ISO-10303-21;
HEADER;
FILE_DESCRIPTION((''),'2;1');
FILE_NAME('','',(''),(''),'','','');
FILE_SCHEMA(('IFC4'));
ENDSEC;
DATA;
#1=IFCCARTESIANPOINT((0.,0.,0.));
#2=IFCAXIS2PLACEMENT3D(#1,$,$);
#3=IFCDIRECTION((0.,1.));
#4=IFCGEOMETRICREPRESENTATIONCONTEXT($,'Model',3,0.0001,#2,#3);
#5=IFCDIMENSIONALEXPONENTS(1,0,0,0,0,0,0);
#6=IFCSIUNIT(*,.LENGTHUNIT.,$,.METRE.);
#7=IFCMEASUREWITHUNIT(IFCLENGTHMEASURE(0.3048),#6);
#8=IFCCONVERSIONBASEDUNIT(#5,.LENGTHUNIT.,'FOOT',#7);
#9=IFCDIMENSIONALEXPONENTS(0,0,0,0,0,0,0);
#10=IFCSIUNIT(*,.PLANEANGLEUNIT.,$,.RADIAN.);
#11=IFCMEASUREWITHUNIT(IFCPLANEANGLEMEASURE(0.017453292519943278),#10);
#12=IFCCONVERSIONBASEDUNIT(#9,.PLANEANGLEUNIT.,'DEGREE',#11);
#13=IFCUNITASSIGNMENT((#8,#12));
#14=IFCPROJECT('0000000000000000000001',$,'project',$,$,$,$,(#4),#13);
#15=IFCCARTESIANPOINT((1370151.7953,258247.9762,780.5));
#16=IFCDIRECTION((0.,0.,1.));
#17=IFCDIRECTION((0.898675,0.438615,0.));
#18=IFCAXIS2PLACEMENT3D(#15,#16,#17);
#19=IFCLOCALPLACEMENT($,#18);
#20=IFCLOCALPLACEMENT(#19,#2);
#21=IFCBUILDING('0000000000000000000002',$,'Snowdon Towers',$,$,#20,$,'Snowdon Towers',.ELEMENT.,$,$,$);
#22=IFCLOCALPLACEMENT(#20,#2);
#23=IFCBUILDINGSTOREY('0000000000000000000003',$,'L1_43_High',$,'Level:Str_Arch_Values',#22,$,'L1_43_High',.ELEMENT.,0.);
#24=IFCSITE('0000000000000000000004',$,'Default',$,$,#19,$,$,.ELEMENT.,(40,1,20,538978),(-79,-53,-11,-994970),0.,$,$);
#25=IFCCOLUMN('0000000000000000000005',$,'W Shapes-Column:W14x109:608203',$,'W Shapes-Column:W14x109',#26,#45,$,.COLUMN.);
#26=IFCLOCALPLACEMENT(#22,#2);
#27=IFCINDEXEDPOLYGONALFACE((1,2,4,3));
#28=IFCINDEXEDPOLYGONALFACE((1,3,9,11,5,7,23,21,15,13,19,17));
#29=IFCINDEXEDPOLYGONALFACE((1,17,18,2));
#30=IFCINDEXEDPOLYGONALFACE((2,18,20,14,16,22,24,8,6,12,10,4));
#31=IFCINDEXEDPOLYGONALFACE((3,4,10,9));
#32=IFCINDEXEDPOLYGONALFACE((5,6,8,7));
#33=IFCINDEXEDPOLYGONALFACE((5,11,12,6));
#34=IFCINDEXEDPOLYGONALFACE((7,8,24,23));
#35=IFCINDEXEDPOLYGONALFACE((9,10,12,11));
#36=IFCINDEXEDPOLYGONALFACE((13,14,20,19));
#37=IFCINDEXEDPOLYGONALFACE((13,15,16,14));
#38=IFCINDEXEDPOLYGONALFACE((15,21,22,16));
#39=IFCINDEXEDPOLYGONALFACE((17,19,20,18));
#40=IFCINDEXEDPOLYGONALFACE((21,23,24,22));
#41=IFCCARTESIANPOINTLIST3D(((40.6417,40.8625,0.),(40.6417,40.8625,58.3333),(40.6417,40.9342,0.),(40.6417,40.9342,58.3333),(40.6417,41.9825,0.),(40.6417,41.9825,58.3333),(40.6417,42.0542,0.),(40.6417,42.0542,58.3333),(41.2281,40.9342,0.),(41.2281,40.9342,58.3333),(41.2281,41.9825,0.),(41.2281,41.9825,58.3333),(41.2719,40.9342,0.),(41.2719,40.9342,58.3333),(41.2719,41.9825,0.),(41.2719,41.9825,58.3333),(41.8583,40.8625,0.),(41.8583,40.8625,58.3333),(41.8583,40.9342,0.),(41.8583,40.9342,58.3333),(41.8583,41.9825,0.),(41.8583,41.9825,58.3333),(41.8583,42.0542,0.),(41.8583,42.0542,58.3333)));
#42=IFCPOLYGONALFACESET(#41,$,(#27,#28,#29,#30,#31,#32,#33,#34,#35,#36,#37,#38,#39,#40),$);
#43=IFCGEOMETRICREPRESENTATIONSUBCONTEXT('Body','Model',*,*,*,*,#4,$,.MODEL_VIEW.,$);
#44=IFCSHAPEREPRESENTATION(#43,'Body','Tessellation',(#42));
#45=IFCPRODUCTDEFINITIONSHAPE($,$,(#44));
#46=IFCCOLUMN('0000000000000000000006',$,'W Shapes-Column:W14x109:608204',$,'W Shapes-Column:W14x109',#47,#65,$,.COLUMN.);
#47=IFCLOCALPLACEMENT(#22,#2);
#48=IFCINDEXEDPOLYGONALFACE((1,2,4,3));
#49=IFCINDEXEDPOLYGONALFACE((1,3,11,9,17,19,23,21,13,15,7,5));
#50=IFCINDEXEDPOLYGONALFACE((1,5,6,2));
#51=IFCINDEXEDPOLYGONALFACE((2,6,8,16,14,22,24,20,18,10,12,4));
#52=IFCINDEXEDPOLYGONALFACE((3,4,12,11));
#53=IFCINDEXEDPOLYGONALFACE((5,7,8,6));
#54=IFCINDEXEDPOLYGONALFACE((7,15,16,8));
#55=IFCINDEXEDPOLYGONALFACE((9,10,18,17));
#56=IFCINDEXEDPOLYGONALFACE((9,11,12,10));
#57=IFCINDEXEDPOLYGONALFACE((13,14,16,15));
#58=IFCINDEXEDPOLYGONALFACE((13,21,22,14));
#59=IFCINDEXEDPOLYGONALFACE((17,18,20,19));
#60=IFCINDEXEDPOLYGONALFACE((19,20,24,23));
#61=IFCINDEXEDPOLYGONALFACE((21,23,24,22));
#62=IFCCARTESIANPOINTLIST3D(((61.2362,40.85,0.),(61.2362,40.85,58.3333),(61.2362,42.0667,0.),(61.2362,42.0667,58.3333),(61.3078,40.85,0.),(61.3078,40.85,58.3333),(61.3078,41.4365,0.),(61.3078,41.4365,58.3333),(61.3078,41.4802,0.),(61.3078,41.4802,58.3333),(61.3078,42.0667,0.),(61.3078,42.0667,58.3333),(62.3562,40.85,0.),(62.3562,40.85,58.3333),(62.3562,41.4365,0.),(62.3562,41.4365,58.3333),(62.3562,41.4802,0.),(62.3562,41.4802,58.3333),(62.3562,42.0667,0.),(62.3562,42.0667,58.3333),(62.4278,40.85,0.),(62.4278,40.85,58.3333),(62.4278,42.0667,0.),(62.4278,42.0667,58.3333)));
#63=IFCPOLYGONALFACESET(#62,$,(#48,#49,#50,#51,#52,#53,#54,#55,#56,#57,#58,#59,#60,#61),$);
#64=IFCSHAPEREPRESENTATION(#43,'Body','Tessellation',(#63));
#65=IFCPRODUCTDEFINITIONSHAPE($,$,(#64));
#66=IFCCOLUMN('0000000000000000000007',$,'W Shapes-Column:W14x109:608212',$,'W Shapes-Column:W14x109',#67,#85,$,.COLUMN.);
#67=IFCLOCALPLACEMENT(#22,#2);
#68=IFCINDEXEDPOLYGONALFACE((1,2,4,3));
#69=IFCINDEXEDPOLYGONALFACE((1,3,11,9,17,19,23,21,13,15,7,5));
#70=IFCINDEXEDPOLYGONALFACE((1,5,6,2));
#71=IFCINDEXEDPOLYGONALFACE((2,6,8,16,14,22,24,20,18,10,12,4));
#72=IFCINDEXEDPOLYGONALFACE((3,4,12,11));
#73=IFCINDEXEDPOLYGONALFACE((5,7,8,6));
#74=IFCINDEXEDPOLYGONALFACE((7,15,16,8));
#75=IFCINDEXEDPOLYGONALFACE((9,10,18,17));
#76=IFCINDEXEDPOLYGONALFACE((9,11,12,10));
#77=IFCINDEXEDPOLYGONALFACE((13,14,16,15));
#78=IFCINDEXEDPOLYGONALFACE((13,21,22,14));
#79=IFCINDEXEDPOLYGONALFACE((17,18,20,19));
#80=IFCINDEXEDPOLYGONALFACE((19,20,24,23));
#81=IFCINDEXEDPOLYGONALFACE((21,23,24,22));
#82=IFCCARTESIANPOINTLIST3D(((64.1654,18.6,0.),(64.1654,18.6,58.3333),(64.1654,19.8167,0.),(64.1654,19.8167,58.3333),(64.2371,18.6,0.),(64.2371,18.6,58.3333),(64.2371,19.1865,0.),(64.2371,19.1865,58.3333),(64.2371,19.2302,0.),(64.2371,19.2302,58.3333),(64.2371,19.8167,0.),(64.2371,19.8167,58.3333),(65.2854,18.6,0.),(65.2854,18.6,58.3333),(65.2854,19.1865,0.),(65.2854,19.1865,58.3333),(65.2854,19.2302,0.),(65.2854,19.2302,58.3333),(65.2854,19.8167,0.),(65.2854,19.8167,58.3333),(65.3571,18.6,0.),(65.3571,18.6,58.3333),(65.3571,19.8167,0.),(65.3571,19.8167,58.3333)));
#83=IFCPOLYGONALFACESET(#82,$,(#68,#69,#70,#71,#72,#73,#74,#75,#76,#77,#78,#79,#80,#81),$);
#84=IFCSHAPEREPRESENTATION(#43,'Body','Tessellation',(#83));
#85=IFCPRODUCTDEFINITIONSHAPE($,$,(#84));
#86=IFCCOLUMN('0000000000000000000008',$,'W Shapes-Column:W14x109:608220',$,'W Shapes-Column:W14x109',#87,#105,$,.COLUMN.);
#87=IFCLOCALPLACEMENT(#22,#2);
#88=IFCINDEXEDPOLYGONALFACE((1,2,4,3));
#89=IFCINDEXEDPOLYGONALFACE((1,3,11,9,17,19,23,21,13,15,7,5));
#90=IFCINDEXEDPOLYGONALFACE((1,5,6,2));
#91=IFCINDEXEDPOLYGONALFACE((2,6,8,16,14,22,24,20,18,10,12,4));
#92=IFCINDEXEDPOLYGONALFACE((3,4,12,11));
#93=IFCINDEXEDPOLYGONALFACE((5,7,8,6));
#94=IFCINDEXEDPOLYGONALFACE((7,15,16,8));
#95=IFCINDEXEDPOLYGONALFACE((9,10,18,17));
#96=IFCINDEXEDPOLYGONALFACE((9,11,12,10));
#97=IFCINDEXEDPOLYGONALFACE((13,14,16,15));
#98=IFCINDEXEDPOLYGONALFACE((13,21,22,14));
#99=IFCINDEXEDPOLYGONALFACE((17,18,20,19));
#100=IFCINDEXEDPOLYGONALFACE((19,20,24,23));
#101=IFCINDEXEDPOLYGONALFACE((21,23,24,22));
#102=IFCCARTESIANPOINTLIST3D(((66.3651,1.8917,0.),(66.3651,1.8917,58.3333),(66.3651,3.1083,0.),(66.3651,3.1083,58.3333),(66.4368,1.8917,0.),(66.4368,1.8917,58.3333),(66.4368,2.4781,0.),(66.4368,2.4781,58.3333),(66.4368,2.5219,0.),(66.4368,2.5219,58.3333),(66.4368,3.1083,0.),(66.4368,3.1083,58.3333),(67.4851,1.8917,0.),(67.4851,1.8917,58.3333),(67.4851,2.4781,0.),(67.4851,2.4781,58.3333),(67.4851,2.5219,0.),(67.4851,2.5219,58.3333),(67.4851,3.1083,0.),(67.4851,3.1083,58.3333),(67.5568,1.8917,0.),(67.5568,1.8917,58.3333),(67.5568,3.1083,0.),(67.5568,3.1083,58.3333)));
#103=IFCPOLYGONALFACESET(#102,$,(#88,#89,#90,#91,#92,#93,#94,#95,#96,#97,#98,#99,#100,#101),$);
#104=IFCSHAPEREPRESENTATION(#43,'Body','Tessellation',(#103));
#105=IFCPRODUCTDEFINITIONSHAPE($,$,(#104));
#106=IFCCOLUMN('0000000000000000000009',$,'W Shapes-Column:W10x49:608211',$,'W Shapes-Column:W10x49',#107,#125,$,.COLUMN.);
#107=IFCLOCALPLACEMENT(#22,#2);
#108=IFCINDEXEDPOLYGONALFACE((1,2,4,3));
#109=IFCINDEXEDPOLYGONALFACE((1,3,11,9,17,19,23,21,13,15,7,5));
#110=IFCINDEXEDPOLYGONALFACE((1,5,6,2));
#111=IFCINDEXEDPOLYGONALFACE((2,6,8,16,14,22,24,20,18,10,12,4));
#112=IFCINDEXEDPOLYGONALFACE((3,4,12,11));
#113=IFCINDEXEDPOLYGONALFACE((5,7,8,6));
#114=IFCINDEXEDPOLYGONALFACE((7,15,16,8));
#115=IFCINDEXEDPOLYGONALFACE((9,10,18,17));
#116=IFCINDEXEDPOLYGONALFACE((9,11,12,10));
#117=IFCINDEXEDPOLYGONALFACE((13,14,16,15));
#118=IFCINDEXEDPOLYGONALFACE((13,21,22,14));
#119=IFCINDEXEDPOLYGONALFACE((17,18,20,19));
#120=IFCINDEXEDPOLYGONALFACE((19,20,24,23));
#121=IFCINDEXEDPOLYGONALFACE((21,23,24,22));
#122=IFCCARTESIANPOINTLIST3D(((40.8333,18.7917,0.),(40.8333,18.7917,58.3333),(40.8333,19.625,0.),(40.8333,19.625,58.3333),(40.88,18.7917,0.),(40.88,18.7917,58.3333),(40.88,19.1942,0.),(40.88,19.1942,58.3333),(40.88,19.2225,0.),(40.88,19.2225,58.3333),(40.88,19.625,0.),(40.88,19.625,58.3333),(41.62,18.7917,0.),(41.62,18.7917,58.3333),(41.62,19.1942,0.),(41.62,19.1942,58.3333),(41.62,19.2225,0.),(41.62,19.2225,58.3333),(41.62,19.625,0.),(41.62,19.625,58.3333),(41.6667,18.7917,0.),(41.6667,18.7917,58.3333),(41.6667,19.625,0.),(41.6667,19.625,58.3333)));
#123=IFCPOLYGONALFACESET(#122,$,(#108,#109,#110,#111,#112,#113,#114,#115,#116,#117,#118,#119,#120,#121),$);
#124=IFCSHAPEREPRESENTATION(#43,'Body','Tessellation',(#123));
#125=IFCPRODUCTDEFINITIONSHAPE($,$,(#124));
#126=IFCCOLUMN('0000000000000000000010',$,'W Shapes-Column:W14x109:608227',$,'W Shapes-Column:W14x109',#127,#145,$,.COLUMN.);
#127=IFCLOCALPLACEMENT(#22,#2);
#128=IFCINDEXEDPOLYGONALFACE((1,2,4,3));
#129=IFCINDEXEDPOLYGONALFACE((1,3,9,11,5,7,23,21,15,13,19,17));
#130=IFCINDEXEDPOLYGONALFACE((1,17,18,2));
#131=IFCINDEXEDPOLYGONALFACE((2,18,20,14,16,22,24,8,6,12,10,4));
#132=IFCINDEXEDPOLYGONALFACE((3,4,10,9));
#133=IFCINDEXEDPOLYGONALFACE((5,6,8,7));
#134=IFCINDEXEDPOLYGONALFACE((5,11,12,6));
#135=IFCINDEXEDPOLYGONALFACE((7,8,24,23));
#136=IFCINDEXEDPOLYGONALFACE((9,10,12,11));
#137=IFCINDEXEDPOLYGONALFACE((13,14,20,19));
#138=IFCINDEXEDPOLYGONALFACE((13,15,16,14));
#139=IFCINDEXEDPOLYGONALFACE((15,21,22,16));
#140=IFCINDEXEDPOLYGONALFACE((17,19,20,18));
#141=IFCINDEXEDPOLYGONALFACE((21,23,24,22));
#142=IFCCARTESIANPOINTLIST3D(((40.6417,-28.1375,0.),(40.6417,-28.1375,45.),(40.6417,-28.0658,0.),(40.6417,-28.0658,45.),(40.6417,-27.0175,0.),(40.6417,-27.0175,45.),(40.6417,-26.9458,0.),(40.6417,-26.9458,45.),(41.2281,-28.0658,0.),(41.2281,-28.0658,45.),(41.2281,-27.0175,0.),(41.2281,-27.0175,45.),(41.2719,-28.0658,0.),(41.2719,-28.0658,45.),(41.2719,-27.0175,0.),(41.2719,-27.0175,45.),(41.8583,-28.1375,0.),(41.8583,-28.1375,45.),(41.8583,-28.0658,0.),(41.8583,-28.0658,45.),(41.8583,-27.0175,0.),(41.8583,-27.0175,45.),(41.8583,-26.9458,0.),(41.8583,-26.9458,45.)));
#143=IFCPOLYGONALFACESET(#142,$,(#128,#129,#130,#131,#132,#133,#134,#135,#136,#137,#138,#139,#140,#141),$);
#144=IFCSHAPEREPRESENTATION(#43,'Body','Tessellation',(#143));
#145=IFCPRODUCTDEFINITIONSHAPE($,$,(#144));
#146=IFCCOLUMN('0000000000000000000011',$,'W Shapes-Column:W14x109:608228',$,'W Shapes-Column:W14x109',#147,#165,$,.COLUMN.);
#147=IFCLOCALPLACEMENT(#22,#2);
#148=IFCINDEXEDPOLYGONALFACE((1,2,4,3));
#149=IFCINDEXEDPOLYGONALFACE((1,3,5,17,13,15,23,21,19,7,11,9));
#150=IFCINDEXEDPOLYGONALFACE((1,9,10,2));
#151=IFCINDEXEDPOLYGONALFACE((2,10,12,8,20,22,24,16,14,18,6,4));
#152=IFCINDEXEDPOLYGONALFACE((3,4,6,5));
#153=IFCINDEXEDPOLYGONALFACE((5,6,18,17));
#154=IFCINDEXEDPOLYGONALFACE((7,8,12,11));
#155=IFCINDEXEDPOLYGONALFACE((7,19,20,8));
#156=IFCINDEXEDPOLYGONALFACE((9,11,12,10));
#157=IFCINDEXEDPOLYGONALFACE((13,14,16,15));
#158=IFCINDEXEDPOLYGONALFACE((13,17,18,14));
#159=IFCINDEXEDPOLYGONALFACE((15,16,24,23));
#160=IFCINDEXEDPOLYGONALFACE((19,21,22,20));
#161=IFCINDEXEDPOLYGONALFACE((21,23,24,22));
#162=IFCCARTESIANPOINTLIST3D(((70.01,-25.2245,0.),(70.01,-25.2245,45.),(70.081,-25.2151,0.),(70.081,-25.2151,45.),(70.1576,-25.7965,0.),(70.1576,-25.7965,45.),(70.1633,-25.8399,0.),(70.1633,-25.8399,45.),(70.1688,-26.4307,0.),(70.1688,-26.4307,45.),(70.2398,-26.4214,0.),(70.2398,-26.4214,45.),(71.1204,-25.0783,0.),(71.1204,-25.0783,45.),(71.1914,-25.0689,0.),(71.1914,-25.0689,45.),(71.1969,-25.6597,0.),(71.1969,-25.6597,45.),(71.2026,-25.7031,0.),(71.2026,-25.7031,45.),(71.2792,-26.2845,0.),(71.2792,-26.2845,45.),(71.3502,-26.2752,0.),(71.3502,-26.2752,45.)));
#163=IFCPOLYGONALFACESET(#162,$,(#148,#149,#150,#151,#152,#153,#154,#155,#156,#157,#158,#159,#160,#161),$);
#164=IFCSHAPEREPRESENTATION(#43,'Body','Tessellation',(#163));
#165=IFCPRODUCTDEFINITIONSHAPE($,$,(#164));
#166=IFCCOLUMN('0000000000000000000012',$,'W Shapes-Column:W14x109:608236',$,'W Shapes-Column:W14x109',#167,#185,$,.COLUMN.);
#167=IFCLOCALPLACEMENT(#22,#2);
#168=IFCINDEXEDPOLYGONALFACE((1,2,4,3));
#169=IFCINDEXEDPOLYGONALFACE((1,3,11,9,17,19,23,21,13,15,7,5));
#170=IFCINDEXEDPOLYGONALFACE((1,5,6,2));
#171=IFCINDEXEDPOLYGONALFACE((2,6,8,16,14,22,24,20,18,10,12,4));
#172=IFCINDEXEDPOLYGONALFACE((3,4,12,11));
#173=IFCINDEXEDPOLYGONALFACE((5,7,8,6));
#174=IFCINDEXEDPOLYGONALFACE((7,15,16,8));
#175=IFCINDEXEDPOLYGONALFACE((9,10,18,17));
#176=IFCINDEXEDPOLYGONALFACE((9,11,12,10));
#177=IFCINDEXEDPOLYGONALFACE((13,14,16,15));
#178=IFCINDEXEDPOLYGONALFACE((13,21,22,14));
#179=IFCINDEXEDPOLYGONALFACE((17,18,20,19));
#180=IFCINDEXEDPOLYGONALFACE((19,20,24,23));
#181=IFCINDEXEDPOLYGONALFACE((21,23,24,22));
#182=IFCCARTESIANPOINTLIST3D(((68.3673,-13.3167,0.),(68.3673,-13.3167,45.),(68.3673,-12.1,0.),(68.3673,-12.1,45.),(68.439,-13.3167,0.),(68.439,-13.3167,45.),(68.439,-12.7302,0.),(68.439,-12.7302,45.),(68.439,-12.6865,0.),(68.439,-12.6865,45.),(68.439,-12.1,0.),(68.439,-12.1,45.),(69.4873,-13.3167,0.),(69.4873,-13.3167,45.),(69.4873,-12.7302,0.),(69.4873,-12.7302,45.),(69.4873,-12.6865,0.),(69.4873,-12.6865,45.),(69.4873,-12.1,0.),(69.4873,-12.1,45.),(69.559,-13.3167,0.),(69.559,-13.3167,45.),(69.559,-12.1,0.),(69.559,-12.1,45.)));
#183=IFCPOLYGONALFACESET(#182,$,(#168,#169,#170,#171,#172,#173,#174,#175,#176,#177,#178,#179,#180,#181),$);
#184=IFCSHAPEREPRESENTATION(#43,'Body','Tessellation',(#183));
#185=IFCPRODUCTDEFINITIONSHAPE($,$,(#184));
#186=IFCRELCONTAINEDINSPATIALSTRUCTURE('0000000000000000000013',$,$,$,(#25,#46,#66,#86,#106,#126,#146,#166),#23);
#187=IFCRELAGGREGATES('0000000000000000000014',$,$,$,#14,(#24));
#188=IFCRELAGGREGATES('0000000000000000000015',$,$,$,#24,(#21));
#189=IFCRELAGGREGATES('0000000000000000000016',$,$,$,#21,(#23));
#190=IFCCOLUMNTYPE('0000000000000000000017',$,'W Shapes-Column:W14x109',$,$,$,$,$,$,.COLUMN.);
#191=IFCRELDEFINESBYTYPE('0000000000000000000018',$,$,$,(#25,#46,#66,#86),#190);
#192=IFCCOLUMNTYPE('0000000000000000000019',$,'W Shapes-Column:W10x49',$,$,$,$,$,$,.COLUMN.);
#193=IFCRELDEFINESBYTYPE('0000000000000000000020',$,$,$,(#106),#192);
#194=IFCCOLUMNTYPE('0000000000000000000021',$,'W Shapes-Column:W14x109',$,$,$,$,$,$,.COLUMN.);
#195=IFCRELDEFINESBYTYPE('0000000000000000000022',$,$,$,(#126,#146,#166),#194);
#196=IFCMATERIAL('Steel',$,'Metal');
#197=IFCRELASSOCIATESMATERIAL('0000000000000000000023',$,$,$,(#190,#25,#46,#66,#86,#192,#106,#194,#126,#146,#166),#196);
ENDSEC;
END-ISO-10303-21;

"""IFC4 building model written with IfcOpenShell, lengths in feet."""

from ifc_helpers import new_model, entity, si_unit, converted_unit, direction, frame, origin, place, context, subcontext, project, spatial, indexed_curve, outline, extrude, source, transform, mapped, material, type_object, type_shapes, element, save


model = new_model("IFC4")

# Units and contexts
model_context = context("Model", 3, precision=0.0001, world=origin(), true_north=direction((0.0, 1.0)))
body_context = subcontext(model_context, "Body", "Model", "MODEL_VIEW")
ifc_project = project(units=[converted_unit("LENGTHUNIT", "FOOT", entity("IfcLengthMeasure", 0.3048), si_unit("LENGTHUNIT", "METRE"), dimensions=[1, 0, 0, 0, 0, 0, 0]), converted_unit("PLANEANGLEUNIT", "DEGREE", entity("IfcPlaneAngleMeasure", 0.017453292519943278), si_unit("PLANEANGLEUNIT", "RADIAN"), dimensions=[0, 0, 0, 0, 0, 0, 0])], contexts=[model_context])

# Site, building, storey
site_placement = place(None, frame((1370151.7953, 258247.9762, 780.5), z_axis=(0.0, 0.0, 1.0), x_axis=(0.898675, 0.438615, 0.0)))
site = spatial("IfcSite", under=ifc_project, at=site_placement, Name="Default", CompositionType="ELEMENT", RefLatitude=(40, 1, 20, 538978), RefLongitude=(-79, -53, -11, -994970), RefElevation=0.0)
building_placement = place(site_placement, origin())
building = spatial("IfcBuilding", under=site, at=building_placement, Name="Snowdon Towers", LongName="Snowdon Towers", CompositionType="ELEMENT")
storey_placement = place(building_placement, origin())
storey = spatial("IfcBuildingStorey", under=building, at=storey_placement, Name="L1_43_High", ObjectType="Level:Str_Arch_Values", LongName="L1_43_High", CompositionType="ELEMENT", Elevation=0.0)

# Columns
ifc_material_1 = material(Name="Steel", Category="Metal")
column_type_1 = type_object("IfcColumnType", Name="W Shapes-Column:W14x109", PredefinedType="COLUMN", material=ifc_material_1)
shared_shape_1 = source(origin(), body_context, "Body", "SweptSolid", [
    extrude(outline(indexed_curve([(-0.6083, -0.5958), (0.6083, -0.5958), (0.6083, -0.5242), (0.0219, -0.5242), (0.0219, 0.5242), (0.6083, 0.5242), (0.6083, 0.5958), (-0.6083, 0.5958), (-0.6083, 0.5242), (-0.0219, 0.5242), (-0.0219, -0.5242), (-0.6083, -0.5242), (-0.6083, -0.5958)], self_intersect=False)), frame((0.0, 0.0, 0.0), z_axis=(0.0, 0.0, 1.0), x_axis=(-1.0, 0.0, 0.0)), (0.0, 0.0, 1.0), 58.3333),
])
type_shapes(column_type_1, [shared_shape_1])
for number, where, z_axis, x_axis, name in (
    (1, (41.25, 41.4583, 0.0), (0.0, 0.0, 1.0), (-1.0, 0.0, 0.0), "W Shapes-Column:W14x109:608203"),
    (2, (61.832, 41.4583, 0.0), (0.0, 0.0, 1.0), (0.0, 1.0, 0.0), "W Shapes-Column:W14x109:608204"),
    (3, (64.7613, 19.2083, 0.0), (0.0, 0.0, 1.0), (0.0, 1.0, 0.0), "W Shapes-Column:W14x109:608212"),
    (4, (66.961, 2.5, 0.0), (0.0, 0.0, 1.0), (0.0, 1.0, 0.0), "W Shapes-Column:W14x109:608220"),
):
    element("IfcColumn", number, at=place(storey_placement, frame(where, z_axis=z_axis, x_axis=x_axis)), inside=storey, type_object=column_type_1, material=ifc_material_1, Name=name, ObjectType="W Shapes-Column:W14x109", PredefinedType="COLUMN", context=body_context, shape_type="MappedRepresentation", body=[
        mapped(shared_shape_1, transform((0.0, 0.0, 0.0), scale=1.0)),
    ])
column_type_2 = type_object("IfcColumnType", Name="W Shapes-Column:W10x49", PredefinedType="COLUMN", material=ifc_material_1)
shared_shape_2 = source(origin(), body_context, "Body", "SweptSolid", [
    extrude(outline(indexed_curve([(-0.4167, -0.4167), (0.4167, -0.4167), (0.4167, -0.37), (0.0142, -0.37), (0.0142, 0.37), (0.4167, 0.37), (0.4167, 0.4167), (-0.4167, 0.4167), (-0.4167, 0.37), (-0.0142, 0.37), (-0.0142, -0.37), (-0.4167, -0.37), (-0.4167, -0.4167)], self_intersect=False)), frame((0.0, 0.0, 0.0), z_axis=(0.0, 0.0, 1.0), x_axis=(-1.0, 0.0, 0.0)), (0.0, 0.0, 1.0), 58.3333),
])
type_shapes(column_type_2, [shared_shape_2])
column_1_placement = place(storey_placement, frame((41.25, 19.2083, 0.0), z_axis=(0.0, 0.0, 1.0), x_axis=(0.0, 1.0, 0.0)))
element("IfcColumn", 5, at=column_1_placement, inside=storey, type_object=column_type_2, material=ifc_material_1, Name="W Shapes-Column:W10x49:608211", ObjectType="W Shapes-Column:W10x49", PredefinedType="COLUMN", context=body_context, shape_type="MappedRepresentation", body=[
    mapped(shared_shape_2, transform((0.0, 0.0, 0.0), scale=1.0)),
])
column_type_3 = type_object("IfcColumnType", Name="W Shapes-Column:W14x109", PredefinedType="COLUMN", material=ifc_material_1)
shared_shape_3 = source(origin(), body_context, "Body", "SweptSolid", [
    extrude(outline(indexed_curve([(-0.6083, -0.5958), (0.6083, -0.5958), (0.6083, -0.5242), (0.0219, -0.5242), (0.0219, 0.5242), (0.6083, 0.5242), (0.6083, 0.5958), (-0.6083, 0.5958), (-0.6083, 0.5242), (-0.0219, 0.5242), (-0.0219, -0.5242), (-0.6083, -0.5242), (-0.6083, -0.5958)], self_intersect=False)), frame((0.0, 0.0, 0.0), z_axis=(0.0, 0.0, 1.0), x_axis=(-1.0, 0.0, 0.0)), (0.0, 0.0, 1.0), 45.0),
])
type_shapes(column_type_3, [shared_shape_3])
for number, where, z_axis, x_axis, name in (
    (6, (41.25, -27.5417, 0.0), (0.0, 0.0, 1.0), (-1.0, 0.0, 0.0), "W Shapes-Column:W14x109:608227"),
    (7, (70.6801, -25.7498, 0.0), (0.0, 0.0, 1.0), (-0.130526, 0.991445, 0.0), "W Shapes-Column:W14x109:608228"),
    (8, (68.9632, -12.7083, 0.0), (0.0, 0.0, 1.0), (0.0, 1.0, 0.0), "W Shapes-Column:W14x109:608236"),
):
    element("IfcColumn", number, at=place(storey_placement, frame(where, z_axis=z_axis, x_axis=x_axis)), inside=storey, type_object=column_type_3, material=ifc_material_1, Name=name, ObjectType="W Shapes-Column:W14x109", PredefinedType="COLUMN", context=body_context, shape_type="MappedRepresentation", body=[
        mapped(shared_shape_3, transform((0.0, 0.0, 0.0), scale=1.0)),
    ])

save(model, "model.ifc")
